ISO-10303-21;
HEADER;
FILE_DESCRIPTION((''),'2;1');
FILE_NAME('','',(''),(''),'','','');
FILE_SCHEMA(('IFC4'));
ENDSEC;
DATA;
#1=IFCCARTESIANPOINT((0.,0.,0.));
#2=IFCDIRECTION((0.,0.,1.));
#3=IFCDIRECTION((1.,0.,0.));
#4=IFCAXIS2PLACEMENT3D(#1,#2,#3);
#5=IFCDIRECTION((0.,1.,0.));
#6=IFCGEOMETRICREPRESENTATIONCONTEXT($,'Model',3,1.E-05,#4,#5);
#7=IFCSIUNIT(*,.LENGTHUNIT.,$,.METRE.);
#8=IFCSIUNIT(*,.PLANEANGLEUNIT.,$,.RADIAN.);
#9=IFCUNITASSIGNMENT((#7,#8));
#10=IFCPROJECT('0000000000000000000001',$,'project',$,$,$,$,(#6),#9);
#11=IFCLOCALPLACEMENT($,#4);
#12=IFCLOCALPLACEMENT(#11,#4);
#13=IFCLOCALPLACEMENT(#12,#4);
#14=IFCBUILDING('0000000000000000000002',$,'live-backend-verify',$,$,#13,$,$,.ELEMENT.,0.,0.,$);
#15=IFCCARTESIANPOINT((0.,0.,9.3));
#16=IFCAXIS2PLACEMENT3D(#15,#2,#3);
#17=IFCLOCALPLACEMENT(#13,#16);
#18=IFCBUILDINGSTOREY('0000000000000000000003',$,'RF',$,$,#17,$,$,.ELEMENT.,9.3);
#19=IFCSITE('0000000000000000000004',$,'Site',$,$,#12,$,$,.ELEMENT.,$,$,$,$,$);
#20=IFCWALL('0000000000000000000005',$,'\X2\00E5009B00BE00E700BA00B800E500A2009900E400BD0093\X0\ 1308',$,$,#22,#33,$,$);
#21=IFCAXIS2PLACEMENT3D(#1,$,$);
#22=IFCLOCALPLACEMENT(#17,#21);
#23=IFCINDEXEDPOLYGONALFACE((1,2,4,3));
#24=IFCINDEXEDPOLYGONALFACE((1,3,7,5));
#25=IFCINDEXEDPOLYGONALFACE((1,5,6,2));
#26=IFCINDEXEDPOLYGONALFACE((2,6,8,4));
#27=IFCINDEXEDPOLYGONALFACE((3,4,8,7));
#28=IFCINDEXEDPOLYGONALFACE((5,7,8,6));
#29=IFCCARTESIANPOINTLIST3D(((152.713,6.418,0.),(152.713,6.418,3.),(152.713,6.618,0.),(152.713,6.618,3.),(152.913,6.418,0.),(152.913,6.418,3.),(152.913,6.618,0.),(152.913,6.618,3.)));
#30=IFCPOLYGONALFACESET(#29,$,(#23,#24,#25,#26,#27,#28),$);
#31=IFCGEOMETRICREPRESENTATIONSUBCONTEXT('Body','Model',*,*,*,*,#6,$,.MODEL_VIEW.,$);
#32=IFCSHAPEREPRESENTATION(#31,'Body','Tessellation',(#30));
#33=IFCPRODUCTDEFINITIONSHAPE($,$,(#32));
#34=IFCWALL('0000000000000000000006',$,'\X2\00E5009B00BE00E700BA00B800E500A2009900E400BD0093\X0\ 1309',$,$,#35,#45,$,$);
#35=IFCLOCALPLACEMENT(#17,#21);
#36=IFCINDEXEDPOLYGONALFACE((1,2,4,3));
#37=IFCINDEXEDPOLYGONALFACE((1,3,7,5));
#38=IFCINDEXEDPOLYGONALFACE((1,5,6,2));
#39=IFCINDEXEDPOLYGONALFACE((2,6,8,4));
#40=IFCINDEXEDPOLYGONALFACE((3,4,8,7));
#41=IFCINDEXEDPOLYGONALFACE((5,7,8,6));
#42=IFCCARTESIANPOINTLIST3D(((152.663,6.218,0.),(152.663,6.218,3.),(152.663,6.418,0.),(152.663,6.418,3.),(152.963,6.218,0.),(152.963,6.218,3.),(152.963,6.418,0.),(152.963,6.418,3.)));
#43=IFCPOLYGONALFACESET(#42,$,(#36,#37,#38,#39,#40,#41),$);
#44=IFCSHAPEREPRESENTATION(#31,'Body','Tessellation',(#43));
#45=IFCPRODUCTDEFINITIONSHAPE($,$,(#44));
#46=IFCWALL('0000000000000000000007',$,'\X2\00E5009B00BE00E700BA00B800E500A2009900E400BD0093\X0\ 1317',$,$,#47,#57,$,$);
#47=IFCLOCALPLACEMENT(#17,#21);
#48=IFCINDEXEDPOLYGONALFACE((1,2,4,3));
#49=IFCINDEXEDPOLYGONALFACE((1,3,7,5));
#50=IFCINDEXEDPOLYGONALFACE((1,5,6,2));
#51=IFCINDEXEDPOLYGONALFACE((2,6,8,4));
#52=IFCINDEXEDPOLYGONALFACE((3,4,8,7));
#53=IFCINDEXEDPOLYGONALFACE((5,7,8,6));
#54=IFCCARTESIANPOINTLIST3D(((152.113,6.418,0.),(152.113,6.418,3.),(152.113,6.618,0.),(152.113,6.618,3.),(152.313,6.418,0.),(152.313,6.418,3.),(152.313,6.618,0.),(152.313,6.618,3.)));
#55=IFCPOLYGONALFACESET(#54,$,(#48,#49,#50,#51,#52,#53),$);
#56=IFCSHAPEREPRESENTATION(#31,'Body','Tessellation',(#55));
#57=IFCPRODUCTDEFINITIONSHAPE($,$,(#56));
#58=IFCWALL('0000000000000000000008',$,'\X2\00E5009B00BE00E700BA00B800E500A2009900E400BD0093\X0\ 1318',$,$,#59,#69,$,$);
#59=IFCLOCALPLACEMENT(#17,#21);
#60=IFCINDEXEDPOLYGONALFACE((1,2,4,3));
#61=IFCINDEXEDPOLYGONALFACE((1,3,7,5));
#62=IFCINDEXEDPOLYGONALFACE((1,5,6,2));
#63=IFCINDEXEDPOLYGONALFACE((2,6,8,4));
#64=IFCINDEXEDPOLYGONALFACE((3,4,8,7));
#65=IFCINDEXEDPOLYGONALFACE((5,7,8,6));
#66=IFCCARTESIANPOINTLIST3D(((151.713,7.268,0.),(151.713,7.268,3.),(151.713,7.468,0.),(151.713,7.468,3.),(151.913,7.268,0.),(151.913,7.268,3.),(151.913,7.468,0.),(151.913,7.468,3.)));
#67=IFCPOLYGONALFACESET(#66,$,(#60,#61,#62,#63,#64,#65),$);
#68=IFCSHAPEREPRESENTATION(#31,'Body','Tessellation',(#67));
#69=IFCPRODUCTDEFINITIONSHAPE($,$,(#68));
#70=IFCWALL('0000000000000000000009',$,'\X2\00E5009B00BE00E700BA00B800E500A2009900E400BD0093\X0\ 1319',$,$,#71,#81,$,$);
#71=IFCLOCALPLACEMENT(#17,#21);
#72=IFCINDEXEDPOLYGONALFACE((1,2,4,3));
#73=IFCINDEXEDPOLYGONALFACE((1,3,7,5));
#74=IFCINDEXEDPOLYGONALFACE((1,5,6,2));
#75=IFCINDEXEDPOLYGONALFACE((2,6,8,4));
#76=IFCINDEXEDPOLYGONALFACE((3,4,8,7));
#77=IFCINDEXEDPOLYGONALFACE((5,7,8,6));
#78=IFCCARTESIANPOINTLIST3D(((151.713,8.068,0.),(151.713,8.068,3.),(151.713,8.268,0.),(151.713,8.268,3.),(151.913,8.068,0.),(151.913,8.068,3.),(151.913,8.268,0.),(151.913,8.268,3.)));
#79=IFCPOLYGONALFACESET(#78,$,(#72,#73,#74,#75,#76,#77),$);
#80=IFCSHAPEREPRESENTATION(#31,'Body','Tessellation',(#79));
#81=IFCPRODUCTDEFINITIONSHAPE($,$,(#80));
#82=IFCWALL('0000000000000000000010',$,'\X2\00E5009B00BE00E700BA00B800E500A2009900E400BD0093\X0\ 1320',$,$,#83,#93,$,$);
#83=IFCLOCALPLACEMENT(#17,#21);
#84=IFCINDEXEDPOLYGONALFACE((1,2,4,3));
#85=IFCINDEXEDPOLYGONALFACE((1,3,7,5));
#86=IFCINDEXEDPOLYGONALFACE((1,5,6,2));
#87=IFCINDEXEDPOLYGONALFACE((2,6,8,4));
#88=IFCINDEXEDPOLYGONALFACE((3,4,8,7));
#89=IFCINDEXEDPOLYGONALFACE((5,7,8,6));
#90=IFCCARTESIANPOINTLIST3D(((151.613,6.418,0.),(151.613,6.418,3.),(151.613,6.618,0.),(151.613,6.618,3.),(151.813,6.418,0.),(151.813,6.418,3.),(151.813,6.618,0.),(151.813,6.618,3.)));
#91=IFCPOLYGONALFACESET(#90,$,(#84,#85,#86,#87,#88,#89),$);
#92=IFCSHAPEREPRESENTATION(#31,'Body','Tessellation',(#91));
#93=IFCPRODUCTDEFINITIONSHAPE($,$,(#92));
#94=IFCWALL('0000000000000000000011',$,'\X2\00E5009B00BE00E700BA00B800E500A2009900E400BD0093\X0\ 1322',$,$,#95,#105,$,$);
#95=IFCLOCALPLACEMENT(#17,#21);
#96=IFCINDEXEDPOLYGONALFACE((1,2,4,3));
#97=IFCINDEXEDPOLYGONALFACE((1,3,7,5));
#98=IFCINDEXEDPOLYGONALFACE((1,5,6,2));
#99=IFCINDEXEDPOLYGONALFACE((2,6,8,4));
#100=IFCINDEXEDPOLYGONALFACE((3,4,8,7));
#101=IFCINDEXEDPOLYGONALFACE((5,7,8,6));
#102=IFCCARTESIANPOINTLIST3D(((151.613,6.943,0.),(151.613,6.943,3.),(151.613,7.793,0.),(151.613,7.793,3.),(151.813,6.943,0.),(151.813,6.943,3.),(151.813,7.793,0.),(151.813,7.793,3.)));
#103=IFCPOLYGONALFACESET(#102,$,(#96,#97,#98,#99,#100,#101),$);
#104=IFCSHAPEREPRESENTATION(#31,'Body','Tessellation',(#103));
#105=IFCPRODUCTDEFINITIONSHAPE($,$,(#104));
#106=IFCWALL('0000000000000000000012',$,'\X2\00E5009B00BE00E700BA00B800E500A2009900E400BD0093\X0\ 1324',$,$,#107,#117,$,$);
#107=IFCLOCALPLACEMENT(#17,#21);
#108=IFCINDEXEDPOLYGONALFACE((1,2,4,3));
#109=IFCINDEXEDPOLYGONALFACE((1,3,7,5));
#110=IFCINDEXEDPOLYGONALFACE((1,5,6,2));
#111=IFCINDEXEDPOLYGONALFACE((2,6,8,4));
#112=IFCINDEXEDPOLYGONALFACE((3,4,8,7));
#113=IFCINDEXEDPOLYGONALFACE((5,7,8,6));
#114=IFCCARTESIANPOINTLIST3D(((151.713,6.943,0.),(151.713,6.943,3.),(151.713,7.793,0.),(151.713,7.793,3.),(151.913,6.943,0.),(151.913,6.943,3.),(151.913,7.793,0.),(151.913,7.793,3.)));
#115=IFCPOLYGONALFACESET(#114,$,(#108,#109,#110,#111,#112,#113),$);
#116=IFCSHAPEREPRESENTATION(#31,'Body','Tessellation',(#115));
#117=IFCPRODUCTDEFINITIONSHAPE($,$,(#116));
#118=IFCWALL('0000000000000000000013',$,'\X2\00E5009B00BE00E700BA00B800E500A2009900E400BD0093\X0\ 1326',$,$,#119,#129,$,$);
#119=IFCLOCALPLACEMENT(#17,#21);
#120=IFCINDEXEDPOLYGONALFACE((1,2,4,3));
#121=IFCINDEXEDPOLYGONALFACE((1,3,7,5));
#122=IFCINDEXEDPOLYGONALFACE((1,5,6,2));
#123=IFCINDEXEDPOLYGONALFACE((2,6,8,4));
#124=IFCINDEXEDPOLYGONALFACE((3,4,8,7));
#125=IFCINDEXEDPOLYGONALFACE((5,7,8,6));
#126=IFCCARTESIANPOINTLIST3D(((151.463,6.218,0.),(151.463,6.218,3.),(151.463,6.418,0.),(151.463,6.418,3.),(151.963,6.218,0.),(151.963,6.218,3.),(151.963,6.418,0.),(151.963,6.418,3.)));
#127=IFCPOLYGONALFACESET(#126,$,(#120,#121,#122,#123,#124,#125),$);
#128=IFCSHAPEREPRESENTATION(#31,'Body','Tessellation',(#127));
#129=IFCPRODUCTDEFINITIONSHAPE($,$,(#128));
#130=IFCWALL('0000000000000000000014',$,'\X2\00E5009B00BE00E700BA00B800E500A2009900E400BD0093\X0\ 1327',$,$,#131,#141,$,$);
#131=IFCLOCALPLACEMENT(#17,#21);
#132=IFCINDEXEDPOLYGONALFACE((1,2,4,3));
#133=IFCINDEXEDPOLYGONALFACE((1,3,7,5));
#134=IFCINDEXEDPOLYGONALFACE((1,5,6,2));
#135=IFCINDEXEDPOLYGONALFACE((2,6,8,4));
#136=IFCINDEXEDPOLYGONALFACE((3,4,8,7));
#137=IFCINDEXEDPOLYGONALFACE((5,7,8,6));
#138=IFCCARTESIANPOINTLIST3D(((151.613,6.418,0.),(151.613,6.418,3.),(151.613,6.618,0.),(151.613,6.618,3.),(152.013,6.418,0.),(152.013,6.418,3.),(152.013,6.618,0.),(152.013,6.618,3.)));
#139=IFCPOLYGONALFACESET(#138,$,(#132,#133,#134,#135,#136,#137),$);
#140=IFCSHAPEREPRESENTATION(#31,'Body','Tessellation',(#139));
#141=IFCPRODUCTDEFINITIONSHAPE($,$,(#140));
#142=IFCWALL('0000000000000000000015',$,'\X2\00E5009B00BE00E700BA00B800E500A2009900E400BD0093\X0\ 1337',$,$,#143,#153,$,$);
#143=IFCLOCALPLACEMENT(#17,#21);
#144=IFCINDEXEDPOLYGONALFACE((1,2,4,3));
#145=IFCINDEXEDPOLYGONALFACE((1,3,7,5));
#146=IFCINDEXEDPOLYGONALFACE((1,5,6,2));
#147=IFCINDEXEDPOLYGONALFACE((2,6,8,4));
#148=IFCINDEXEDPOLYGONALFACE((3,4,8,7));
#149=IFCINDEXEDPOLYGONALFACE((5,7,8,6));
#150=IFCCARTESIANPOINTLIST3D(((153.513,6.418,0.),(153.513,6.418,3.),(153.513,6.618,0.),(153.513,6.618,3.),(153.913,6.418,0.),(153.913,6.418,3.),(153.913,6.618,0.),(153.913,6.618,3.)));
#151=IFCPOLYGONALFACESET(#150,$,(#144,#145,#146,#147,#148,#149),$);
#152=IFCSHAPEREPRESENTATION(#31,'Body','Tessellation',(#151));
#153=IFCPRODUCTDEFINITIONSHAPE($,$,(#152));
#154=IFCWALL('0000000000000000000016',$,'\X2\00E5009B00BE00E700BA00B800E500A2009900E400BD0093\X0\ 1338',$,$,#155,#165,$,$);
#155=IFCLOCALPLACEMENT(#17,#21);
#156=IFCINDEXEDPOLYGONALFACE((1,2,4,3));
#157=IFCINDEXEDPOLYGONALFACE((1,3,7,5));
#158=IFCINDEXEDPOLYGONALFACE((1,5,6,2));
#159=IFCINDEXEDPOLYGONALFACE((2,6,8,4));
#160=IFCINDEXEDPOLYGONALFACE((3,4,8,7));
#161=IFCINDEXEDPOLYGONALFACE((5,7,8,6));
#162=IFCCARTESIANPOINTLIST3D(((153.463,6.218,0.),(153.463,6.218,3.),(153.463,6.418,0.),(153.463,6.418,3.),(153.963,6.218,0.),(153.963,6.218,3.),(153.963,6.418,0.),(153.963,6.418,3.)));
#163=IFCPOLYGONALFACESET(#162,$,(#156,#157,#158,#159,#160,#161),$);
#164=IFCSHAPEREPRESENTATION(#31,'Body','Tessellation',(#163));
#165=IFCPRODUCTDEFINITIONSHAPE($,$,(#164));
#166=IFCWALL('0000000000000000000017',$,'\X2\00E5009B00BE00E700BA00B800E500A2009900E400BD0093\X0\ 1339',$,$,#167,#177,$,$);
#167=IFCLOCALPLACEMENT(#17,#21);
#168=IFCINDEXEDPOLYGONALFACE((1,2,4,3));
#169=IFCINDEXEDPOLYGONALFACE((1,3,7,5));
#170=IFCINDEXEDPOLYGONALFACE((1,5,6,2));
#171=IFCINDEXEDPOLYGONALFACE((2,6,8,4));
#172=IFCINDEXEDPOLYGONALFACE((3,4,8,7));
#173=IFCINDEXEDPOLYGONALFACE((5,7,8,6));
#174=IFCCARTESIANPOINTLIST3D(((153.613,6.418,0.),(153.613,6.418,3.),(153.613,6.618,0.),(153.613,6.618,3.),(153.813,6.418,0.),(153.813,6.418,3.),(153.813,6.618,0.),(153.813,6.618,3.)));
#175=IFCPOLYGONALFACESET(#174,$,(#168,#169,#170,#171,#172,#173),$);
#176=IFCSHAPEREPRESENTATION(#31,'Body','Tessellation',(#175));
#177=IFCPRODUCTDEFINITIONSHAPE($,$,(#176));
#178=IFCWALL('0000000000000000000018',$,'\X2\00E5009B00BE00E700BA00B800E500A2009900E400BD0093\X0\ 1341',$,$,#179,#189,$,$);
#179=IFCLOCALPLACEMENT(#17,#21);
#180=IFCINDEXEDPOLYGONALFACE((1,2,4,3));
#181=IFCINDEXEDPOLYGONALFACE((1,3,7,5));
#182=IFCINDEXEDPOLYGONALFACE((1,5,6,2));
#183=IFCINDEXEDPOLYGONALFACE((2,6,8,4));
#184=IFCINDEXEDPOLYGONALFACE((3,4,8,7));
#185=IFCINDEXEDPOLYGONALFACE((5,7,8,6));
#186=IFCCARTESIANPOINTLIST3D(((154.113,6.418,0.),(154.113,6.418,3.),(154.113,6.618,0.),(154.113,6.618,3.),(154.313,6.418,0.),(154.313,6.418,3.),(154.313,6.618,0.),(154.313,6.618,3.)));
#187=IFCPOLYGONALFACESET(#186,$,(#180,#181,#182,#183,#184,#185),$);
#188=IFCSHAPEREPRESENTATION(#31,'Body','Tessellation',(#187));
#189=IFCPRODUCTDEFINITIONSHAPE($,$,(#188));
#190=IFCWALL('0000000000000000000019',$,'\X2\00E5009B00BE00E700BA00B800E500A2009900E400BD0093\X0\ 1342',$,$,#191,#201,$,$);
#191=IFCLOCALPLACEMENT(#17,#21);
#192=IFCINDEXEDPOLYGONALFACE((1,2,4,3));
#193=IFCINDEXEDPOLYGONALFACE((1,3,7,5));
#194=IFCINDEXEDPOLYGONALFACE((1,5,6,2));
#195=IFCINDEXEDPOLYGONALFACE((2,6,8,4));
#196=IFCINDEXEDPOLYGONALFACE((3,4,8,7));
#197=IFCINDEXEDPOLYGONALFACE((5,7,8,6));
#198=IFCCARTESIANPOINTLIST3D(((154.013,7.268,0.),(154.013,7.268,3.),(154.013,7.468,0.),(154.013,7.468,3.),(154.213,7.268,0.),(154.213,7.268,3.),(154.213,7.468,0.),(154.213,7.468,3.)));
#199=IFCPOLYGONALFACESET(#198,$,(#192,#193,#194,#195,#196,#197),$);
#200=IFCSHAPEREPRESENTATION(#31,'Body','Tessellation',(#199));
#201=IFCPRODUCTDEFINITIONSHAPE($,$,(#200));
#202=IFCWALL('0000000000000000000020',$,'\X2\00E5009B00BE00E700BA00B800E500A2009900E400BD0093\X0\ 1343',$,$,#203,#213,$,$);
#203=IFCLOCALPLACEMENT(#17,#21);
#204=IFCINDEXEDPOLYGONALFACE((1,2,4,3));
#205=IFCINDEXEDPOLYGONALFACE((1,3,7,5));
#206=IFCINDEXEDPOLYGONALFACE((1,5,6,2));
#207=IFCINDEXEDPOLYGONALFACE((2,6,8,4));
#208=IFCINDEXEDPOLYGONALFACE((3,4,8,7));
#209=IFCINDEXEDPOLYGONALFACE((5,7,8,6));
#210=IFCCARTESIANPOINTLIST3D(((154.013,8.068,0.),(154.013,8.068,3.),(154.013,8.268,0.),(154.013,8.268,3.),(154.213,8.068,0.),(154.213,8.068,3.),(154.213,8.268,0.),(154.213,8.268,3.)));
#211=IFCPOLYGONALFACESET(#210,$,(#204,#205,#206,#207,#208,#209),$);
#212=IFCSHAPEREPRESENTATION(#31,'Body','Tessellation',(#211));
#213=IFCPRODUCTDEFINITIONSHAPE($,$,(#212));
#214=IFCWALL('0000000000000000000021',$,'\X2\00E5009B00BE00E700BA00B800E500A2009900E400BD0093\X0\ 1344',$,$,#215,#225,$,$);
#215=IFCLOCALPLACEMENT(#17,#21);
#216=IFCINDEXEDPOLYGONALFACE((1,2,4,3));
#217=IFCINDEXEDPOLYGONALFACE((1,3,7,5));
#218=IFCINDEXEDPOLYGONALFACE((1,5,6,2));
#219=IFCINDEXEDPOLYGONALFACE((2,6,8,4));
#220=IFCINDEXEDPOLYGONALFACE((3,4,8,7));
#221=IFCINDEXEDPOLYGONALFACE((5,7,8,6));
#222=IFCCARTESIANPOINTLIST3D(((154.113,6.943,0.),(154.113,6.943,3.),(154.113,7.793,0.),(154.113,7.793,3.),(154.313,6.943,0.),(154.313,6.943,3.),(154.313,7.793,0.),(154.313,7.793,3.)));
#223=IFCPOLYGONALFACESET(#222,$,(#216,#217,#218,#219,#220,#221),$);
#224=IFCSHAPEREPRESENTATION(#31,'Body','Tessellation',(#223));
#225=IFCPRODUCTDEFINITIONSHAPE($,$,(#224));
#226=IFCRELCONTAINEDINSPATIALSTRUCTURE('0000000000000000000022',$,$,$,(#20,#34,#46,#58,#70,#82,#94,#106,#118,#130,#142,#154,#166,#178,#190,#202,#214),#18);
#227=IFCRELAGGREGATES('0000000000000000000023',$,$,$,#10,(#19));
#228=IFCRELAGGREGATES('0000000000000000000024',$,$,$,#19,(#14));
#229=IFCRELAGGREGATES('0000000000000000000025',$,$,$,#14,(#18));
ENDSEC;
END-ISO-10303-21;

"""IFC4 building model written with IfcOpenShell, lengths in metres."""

from ifc_helpers import new_model, si_unit, direction, frame, frame_2d, origin_with_axes, place, context, subcontext, project, spatial, rectangle, extrude, element, save


model = new_model("IFC4")

# Units and contexts
model_context = context("Model", 3, precision=1e-05, world=origin_with_axes(), true_north=direction((0.0, 1.0, 0.0)))
body_context = subcontext(model_context, "Body", "Model", "MODEL_VIEW")
ifc_project = project(units=[si_unit("LENGTHUNIT", "METRE"), si_unit("PLANEANGLEUNIT", "RADIAN")], contexts=[model_context])

# Site, building, storey
placement = place(None, origin_with_axes())
site_placement = place(placement, origin_with_axes())
site = spatial("IfcSite", under=ifc_project, at=site_placement, Name="Site", CompositionType="ELEMENT")
building_placement = place(site_placement, origin_with_axes())
building = spatial("IfcBuilding", under=site, at=building_placement, Name="live-backend-verify", CompositionType="ELEMENT", ElevationOfRefHeight=0.0, ElevationOfTerrain=0.0)
storey_placement = place(building_placement, frame((0.0, 0.0, 9.3), z_axis=(0.0, 0.0, 1.0), x_axis=(1.0, 0.0, 0.0)))
storey = spatial("IfcBuildingStorey", under=building, at=storey_placement, Name="RF", CompositionType="ELEMENT", Elevation=9.3)

# Walls
wall_1_placement = place(storey_placement, frame((152.813, 6.518, 0.0), z_axis=(0.0, 0.0, 1.0), x_axis=(1.0, 0.0, 0.0)))
element("IfcWall", 1, at=wall_1_placement, inside=storey, Name="å\u009b¾çº¸å¢\u0099ä½\u0093 1308", context=body_context, shape_type="SweptSolid", body=[
    extrude(rectangle(XDim=0.2, YDim=0.2, at=frame_2d((0.0, 0.0), x_axis=(1.0, 0.0, 0.0))), frame((0.0, 0.0, 0.0), z_axis=(0.0, 0.0, 1.0)), (0.0, 0.0, 1.0), 3.0),
])
wall_2_placement = place(storey_placement, frame((152.813, 6.318, 0.0), z_axis=(0.0, 0.0, 1.0), x_axis=(1.0, 0.0, 0.0)))
element("IfcWall", 2, at=wall_2_placement, inside=storey, Name="å\u009b¾çº¸å¢\u0099ä½\u0093 1309", context=body_context, shape_type="SweptSolid", body=[
    extrude(rectangle(XDim=0.3, YDim=0.2, at=frame_2d((0.0, 0.0), x_axis=(1.0, 0.0, 0.0))), frame((0.0, 0.0, 0.0), z_axis=(0.0, 0.0, 1.0)), (0.0, 0.0, 1.0), 3.0),
])
for number, where, z_axis, x_axis, name in (
    (3, (152.213, 6.518, 0.0), (0.0, 0.0, 1.0), (0.0, -1.0, 0.0), "å\u009b¾çº¸å¢\u0099ä½\u0093 1317"),
    (4, (151.813, 7.368, 0.0), (0.0, 0.0, 1.0), (-1.0, 0.0, 0.0), "å\u009b¾çº¸å¢\u0099ä½\u0093 1318"),
    (5, (151.813, 8.168, 0.0), (0.0, 0.0, 1.0), (-1.0, 0.0, 0.0), "å\u009b¾çº¸å¢\u0099ä½\u0093 1319"),
    (6, (151.713, 6.518, 0.0), (0.0, 0.0, 1.0), (0.0, -1.0, 0.0), "å\u009b¾çº¸å¢\u0099ä½\u0093 1320"),
):
    element("IfcWall", number, at=place(storey_placement, frame(where, z_axis=z_axis, x_axis=x_axis)), inside=storey, Name=name, context=body_context, shape_type="SweptSolid", body=[
        extrude(rectangle(XDim=0.2, YDim=0.2, at=frame_2d((0.0, 0.0), x_axis=(1.0, 0.0, 0.0))), frame((0.0, 0.0, 0.0), z_axis=(0.0, 0.0, 1.0)), (0.0, 0.0, 1.0), 3.0),
    ])
for number, where, z_axis, x_axis, name in (
    (7, (151.713, 7.368, 0.0), (0.0, 0.0, 1.0), (0.0, -1.0, 0.0), "å\u009b¾çº¸å¢\u0099ä½\u0093 1322"),
    (8, (151.813, 7.368, 0.0), (0.0, 0.0, 1.0), (0.0, -1.0, 0.0), "å\u009b¾çº¸å¢\u0099ä½\u0093 1324"),
):
    element("IfcWall", number, at=place(storey_placement, frame(where, z_axis=z_axis, x_axis=x_axis)), inside=storey, Name=name, context=body_context, shape_type="SweptSolid", body=[
        extrude(rectangle(XDim=0.85, YDim=0.2, at=frame_2d((0.0, 0.0), x_axis=(1.0, 0.0, 0.0))), frame((0.0, 0.0, 0.0), z_axis=(0.0, 0.0, 1.0)), (0.0, 0.0, 1.0), 3.0),
    ])
wall_3_placement = place(storey_placement, frame((151.713, 6.318, 0.0), z_axis=(0.0, 0.0, 1.0), x_axis=(1.0, 0.0, 0.0)))
element("IfcWall", 9, at=wall_3_placement, inside=storey, Name="å\u009b¾çº¸å¢\u0099ä½\u0093 1326", context=body_context, shape_type="SweptSolid", body=[
    extrude(rectangle(XDim=0.5, YDim=0.2, at=frame_2d((0.0, 0.0), x_axis=(1.0, 0.0, 0.0))), frame((0.0, 0.0, 0.0), z_axis=(0.0, 0.0, 1.0)), (0.0, 0.0, 1.0), 3.0),
])
for number, where, z_axis, x_axis, name in (
    (10, (151.813, 6.518, 0.0), (0.0, 0.0, 1.0), (1.0, 0.0, 0.0), "å\u009b¾çº¸å¢\u0099ä½\u0093 1327"),
    (11, (153.713, 6.518, 0.0), (0.0, 0.0, 1.0), (1.0, 0.0, 0.0), "å\u009b¾çº¸å¢\u0099ä½\u0093 1337"),
):
    element("IfcWall", number, at=place(storey_placement, frame(where, z_axis=z_axis, x_axis=x_axis)), inside=storey, Name=name, context=body_context, shape_type="SweptSolid", body=[
        extrude(rectangle(XDim=0.4, YDim=0.2, at=frame_2d((0.0, 0.0), x_axis=(1.0, 0.0, 0.0))), frame((0.0, 0.0, 0.0), z_axis=(0.0, 0.0, 1.0)), (0.0, 0.0, 1.0), 3.0),
    ])
wall_4_placement = place(storey_placement, frame((153.713, 6.318, 0.0), z_axis=(0.0, 0.0, 1.0), x_axis=(1.0, 0.0, 0.0)))
element("IfcWall", 12, at=wall_4_placement, inside=storey, Name="å\u009b¾çº¸å¢\u0099ä½\u0093 1338", context=body_context, shape_type="SweptSolid", body=[
    extrude(rectangle(XDim=0.5, YDim=0.2, at=frame_2d((0.0, 0.0), x_axis=(1.0, 0.0, 0.0))), frame((0.0, 0.0, 0.0), z_axis=(0.0, 0.0, 1.0)), (0.0, 0.0, 1.0), 3.0),
])
for number, where, z_axis, x_axis, name in (
    (13, (153.713, 6.518, 0.0), (0.0, 0.0, 1.0), (0.0, -1.0, 0.0), "å\u009b¾çº¸å¢\u0099ä½\u0093 1339"),
    (14, (154.213, 6.518, 0.0), (0.0, 0.0, 1.0), (0.0, -1.0, 0.0), "å\u009b¾çº¸å¢\u0099ä½\u0093 1341"),
    (15, (154.113, 7.368, 0.0), (0.0, 0.0, 1.0), (1.0, 0.0, 0.0), "å\u009b¾çº¸å¢\u0099ä½\u0093 1342"),
    (16, (154.113, 8.168, 0.0), (0.0, 0.0, 1.0), (1.0, 0.0, 0.0), "å\u009b¾çº¸å¢\u0099ä½\u0093 1343"),
):
    element("IfcWall", number, at=place(storey_placement, frame(where, z_axis=z_axis, x_axis=x_axis)), inside=storey, Name=name, context=body_context, shape_type="SweptSolid", body=[
        extrude(rectangle(XDim=0.2, YDim=0.2, at=frame_2d((0.0, 0.0), x_axis=(1.0, 0.0, 0.0))), frame((0.0, 0.0, 0.0), z_axis=(0.0, 0.0, 1.0)), (0.0, 0.0, 1.0), 3.0),
    ])
for number, where, z_axis, x_axis, name in (
    (17, (154.213, 7.368, 0.0), (0.0, 0.0, 1.0), (0.0, -1.0, 0.0), "å\u009b¾çº¸å¢\u0099ä½\u0093 1344"),
):
    element("IfcWall", number, at=place(storey_placement, frame(where, z_axis=z_axis, x_axis=x_axis)), inside=storey, Name=name, context=body_context, shape_type="SweptSolid", body=[
        extrude(rectangle(XDim=0.85, YDim=0.2, at=frame_2d((0.0, 0.0), x_axis=(1.0, 0.0, 0.0))), frame((0.0, 0.0, 0.0), z_axis=(0.0, 0.0, 1.0)), (0.0, 0.0, 1.0), 3.0),
    ])

save(model, "model.ifc")
